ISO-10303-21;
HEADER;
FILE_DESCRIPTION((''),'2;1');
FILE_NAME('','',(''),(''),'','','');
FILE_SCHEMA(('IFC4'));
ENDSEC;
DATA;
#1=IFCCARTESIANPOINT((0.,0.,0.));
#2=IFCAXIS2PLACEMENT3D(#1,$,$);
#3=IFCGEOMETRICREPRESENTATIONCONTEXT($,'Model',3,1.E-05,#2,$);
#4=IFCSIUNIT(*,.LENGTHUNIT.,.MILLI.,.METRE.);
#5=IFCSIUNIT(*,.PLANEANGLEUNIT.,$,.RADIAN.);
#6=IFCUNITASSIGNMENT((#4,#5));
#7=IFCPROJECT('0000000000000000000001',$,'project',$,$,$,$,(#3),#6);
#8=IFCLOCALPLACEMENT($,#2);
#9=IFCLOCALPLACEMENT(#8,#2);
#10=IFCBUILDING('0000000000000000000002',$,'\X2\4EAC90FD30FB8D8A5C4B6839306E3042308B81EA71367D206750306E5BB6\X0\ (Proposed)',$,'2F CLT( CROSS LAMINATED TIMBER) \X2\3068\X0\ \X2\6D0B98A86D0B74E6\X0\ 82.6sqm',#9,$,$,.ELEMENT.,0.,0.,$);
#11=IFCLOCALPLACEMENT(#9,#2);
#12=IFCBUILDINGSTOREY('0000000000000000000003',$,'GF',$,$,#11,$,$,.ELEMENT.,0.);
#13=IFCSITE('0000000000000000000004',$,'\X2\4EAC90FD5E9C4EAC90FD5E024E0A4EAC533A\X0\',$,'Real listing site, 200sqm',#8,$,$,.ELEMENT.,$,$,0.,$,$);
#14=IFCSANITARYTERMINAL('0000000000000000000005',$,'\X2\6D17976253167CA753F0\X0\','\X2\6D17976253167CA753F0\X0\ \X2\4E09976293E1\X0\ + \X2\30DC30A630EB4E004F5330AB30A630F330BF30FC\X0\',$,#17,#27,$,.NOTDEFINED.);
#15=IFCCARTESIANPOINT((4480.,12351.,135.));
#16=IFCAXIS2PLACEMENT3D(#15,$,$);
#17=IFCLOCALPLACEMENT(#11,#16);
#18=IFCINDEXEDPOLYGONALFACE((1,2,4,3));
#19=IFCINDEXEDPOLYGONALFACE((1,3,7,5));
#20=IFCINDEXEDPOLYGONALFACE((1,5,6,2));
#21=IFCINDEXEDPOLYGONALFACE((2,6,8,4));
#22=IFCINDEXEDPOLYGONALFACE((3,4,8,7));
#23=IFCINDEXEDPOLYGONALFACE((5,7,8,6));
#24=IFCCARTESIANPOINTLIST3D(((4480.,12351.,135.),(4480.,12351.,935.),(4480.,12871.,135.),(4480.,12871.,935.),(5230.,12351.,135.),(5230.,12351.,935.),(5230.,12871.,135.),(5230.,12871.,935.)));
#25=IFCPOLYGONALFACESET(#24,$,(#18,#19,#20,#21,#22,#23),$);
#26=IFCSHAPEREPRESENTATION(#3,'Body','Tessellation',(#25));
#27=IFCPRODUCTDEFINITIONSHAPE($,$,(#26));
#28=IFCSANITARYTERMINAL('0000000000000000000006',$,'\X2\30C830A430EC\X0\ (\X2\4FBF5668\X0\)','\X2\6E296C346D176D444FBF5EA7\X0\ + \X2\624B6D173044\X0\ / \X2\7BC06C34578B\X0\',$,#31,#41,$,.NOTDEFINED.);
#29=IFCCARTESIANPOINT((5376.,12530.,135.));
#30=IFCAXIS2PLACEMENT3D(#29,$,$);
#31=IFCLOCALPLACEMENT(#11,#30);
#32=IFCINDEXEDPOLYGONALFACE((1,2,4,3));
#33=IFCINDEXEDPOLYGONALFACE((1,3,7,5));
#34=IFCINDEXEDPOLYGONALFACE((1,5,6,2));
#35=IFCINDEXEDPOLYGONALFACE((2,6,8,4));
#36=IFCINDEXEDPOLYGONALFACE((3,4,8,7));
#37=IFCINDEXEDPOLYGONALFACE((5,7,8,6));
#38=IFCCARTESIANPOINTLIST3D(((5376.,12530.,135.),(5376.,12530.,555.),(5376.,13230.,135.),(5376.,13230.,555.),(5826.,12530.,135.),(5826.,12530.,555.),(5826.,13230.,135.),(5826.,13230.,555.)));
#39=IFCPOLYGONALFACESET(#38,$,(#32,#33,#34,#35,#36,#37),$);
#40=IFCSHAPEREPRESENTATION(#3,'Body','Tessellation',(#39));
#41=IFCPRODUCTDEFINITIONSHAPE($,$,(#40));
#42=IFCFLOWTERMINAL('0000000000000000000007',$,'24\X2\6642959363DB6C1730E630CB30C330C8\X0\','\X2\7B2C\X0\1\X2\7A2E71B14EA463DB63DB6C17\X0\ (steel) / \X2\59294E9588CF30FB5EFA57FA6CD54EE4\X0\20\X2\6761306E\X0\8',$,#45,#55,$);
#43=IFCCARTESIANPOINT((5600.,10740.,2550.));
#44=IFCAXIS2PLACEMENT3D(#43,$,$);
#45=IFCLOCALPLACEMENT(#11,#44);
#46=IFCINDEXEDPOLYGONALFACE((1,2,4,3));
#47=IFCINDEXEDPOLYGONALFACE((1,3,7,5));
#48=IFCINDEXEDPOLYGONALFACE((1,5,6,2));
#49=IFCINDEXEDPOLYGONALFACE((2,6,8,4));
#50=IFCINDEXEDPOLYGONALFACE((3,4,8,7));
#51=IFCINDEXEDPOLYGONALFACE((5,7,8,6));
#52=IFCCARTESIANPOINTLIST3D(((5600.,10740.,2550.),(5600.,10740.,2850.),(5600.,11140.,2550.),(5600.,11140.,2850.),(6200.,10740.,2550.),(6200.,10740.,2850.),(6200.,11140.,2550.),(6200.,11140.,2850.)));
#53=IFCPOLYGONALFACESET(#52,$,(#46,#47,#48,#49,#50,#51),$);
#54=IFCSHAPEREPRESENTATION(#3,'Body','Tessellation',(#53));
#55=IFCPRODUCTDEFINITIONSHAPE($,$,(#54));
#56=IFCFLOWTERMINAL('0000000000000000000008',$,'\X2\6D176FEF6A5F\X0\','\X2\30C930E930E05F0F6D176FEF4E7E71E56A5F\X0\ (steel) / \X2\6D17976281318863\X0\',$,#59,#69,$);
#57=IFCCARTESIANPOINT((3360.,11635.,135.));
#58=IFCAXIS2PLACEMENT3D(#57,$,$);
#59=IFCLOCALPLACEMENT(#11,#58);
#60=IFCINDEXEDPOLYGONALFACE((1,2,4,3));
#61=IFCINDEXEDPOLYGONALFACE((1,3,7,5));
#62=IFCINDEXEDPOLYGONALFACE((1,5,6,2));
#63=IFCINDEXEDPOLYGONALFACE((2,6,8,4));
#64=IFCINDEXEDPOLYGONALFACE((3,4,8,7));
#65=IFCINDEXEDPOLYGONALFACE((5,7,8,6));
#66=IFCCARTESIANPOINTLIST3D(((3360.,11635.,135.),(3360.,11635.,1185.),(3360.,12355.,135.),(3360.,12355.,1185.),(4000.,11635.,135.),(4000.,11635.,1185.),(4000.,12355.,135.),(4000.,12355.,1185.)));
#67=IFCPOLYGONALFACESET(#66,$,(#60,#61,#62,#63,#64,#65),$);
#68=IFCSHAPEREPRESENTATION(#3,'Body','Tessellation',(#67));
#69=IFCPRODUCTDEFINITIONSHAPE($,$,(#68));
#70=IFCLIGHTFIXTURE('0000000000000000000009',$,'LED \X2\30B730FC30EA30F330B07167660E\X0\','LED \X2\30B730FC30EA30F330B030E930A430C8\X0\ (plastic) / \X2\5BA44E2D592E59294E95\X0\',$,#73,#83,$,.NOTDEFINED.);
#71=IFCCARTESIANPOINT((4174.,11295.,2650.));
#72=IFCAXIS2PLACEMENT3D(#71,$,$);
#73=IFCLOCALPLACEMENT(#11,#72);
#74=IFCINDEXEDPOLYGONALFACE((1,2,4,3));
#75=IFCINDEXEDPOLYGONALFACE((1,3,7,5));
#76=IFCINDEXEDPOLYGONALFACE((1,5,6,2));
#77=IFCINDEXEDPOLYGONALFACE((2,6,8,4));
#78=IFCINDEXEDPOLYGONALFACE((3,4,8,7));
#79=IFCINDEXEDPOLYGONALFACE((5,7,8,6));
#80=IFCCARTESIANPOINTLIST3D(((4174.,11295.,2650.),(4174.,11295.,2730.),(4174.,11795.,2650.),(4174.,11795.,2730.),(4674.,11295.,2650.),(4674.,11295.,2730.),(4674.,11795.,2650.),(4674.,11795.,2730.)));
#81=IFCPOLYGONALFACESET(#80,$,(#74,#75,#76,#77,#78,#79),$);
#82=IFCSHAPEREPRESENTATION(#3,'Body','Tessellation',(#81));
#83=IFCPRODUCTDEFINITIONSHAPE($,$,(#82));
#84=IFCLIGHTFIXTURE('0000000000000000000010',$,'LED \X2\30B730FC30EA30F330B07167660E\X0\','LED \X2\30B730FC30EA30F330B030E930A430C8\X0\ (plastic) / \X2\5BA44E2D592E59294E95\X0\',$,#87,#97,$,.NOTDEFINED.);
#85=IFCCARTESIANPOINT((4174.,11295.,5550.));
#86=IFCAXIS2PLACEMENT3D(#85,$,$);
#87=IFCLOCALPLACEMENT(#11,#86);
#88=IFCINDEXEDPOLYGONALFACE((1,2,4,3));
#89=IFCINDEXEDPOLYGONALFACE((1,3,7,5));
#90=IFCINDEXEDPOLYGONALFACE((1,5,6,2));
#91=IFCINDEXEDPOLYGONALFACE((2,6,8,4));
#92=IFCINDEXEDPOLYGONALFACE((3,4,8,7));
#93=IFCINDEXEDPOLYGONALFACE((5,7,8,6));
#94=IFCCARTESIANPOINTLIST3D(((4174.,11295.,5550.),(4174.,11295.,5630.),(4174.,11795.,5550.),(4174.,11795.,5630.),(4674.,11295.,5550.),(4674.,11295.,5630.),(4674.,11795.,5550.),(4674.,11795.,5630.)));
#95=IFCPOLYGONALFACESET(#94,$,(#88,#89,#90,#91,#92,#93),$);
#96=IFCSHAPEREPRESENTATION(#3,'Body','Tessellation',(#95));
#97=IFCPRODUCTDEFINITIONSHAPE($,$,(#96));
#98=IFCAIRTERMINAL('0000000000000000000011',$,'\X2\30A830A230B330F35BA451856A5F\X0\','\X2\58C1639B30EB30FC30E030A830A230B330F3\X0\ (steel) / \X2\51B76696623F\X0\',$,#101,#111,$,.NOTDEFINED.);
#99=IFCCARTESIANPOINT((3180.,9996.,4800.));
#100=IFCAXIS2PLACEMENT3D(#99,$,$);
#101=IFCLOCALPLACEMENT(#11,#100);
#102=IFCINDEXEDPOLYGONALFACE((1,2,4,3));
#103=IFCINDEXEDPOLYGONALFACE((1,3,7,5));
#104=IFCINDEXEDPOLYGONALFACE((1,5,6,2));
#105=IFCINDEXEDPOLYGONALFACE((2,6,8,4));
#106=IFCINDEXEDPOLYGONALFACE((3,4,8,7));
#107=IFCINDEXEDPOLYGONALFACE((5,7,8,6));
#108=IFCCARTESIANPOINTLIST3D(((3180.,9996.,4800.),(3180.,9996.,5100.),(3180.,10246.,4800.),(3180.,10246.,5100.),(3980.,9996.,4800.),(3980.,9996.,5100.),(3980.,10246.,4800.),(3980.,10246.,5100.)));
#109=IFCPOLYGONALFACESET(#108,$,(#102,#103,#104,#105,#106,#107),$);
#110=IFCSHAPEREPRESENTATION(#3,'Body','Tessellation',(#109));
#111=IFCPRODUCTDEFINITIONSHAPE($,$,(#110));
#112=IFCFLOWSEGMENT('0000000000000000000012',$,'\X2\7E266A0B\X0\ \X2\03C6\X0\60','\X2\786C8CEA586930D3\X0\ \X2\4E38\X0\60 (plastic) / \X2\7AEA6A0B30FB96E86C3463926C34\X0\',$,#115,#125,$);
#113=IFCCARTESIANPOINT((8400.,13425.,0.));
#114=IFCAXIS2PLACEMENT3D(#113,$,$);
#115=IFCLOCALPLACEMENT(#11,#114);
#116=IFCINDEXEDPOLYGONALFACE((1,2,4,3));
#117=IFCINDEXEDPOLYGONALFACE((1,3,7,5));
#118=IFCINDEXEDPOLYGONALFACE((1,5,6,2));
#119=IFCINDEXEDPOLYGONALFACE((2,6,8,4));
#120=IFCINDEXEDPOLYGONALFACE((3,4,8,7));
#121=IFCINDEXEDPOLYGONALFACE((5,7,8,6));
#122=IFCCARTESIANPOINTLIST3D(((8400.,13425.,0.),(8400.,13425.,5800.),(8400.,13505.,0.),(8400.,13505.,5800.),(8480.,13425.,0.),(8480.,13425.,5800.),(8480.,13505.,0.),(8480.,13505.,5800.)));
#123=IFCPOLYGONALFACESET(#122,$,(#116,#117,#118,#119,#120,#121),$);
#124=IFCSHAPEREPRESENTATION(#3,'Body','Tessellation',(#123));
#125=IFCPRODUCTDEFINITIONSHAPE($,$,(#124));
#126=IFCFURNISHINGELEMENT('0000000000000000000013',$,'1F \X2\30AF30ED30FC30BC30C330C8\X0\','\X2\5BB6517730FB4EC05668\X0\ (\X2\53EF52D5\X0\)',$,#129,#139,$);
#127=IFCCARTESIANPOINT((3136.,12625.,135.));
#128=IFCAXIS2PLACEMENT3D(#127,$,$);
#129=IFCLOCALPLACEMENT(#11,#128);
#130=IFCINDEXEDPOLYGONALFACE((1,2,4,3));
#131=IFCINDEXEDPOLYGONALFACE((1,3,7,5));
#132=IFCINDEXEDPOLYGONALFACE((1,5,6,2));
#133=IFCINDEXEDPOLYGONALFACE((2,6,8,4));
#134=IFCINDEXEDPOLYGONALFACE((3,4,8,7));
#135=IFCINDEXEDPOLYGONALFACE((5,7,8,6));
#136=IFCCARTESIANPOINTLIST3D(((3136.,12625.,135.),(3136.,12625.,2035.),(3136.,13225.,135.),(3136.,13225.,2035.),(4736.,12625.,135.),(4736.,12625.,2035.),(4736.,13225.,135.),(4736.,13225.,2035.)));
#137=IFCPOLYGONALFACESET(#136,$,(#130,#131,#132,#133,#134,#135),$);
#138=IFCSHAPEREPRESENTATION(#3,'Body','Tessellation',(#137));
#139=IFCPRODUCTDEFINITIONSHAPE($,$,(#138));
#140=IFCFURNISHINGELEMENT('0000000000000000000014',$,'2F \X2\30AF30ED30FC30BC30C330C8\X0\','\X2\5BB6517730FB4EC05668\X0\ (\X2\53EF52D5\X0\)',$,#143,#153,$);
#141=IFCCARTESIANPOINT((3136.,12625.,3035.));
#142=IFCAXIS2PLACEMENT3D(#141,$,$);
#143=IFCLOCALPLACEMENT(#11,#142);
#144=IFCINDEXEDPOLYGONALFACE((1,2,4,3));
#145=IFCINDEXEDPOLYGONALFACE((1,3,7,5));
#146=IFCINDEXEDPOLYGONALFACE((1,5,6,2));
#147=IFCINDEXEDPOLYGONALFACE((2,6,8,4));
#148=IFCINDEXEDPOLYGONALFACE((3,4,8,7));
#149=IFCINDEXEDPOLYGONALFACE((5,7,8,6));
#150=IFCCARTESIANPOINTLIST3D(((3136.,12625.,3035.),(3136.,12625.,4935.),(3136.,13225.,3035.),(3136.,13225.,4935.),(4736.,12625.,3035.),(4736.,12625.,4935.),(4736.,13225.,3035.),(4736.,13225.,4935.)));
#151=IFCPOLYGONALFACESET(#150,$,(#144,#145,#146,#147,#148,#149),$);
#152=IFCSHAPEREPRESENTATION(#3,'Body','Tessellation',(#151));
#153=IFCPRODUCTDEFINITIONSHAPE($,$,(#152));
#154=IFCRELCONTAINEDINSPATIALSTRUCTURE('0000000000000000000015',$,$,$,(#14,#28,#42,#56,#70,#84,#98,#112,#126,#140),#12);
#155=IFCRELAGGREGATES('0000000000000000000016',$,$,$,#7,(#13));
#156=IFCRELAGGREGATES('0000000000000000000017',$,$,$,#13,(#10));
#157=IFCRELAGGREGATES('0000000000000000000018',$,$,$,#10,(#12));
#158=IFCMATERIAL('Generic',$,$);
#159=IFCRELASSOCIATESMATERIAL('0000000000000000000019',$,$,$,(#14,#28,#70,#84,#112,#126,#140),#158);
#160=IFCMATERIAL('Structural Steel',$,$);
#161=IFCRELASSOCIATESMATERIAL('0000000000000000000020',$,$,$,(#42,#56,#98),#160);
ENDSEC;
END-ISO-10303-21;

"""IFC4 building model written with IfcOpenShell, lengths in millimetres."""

from ifc_helpers import new_model, si_unit, frame, frame_2d, origin, place, context, project, spatial, rectangle, extrude, material, element, save


model = new_model("IFC4")

# Units and contexts
model_context = context("Model", 3, precision=1e-05, world=origin())
ifc_project = project(units=[si_unit("LENGTHUNIT", "METRE", prefix="MILLI"), si_unit("PLANEANGLEUNIT", "RADIAN")], contexts=[model_context])

# Site, building, storey
site_placement = place(None, origin())
site = spatial("IfcSite", under=ifc_project, at=site_placement, Name="京都府京都市上京区", ObjectType="Real listing site, 200sqm", CompositionType="ELEMENT", RefElevation=0.0)
building_placement = place(site_placement, origin())
building = spatial("IfcBuilding", under=site, at=building_placement, Name="京都・越屋根のある自然素材の家 (Proposed)", ObjectType="2F CLT( CROSS LAMINATED TIMBER) と 洋風洋瓦 82.6sqm", CompositionType="ELEMENT", ElevationOfRefHeight=0.0, ElevationOfTerrain=0.0)
storey_placement = place(building_placement, origin())
storey = spatial("IfcBuildingStorey", under=building, at=storey_placement, Name="GF", CompositionType="ELEMENT", Elevation=0.0)

# Sanitary terminals
ifc_material_1 = material(Name="Generic")
sanitary_terminal_1_placement = place(storey_placement, frame((4480.0, 12351.0, 135.0)))
element("IfcSanitaryTerminal", 1, at=sanitary_terminal_1_placement, inside=storey, material=ifc_material_1, Name="洗面化粧台", Description="洗面化粧台 三面鏡 + ボウル一体カウンター", PredefinedType="NOTDEFINED", context=model_context, shape_type="SweptSolid", body=[
    extrude(rectangle(XDim=750.0, YDim=520.0, at=frame_2d((375.0, 260.0))), frame((4480.0, 12351.0, 135.0)), (0.0, 0.0, 1.0), 800.0),
])
sanitary_terminal_2_placement = place(storey_placement, frame((5376.0, 12530.0, 135.0)))
element("IfcSanitaryTerminal", 2, at=sanitary_terminal_2_placement, inside=storey, material=ifc_material_1, Name="トイレ (便器)", Description="温水洗浄便座 + 手洗い / 節水型", PredefinedType="NOTDEFINED", context=model_context, shape_type="SweptSolid", body=[
    extrude(rectangle(XDim=450.0, YDim=700.0, at=frame_2d((225.0, 350.0))), frame((5376.0, 12530.0, 135.0)), (0.0, 0.0, 1.0), 420.0),
])

# Flow terminals
ifc_material_2 = material(Name="Structural Steel")
flow_terminal_1_placement = place(storey_placement, frame((5600.0, 10740.0, 2550.0)))
element("IfcFlowTerminal", 3, at=flow_terminal_1_placement, inside=storey, material=ifc_material_2, Name="24時間換気ユニット", Description="第1種熱交換換気 (steel) / 天井裏・建基法令20条の8", context=model_context, shape_type="SweptSolid", body=[
    extrude(rectangle(XDim=600.0, YDim=400.0, at=frame_2d((300.0, 200.0))), frame((5600.0, 10740.0, 2550.0)), (0.0, 0.0, 1.0), 300.0),
])
flow_terminal_2_placement = place(storey_placement, frame((3360.0, 11635.0, 135.0)))
element("IfcFlowTerminal", 4, at=flow_terminal_2_placement, inside=storey, material=ifc_material_2, Name="洗濯機", Description="ドラム式洗濯乾燥機 (steel) / 洗面脱衣", context=model_context, shape_type="SweptSolid", body=[
    extrude(rectangle(XDim=640.0, YDim=720.0, at=frame_2d((320.0, 360.0))), frame((3360.0, 11635.0, 135.0)), (0.0, 0.0, 1.0), 1050.0),
])

# Light fixtures
light_fixture_1_placement = place(storey_placement, frame((4174.0, 11295.0, 2650.0)))
element("IfcLightFixture", 5, at=light_fixture_1_placement, inside=storey, material=ifc_material_1, Name="LED シーリング照明", Description="LED シーリングライト (plastic) / 室中央天井", PredefinedType="NOTDEFINED", context=model_context, shape_type="SweptSolid", body=[
    extrude(rectangle(XDim=500.0, YDim=500.0, at=frame_2d((250.0, 250.0))), frame((4174.0, 11295.0, 2650.0)), (0.0, 0.0, 1.0), 80.0),
])
light_fixture_2_placement = place(storey_placement, frame((4174.0, 11295.0, 5550.0)))
element("IfcLightFixture", 6, at=light_fixture_2_placement, inside=storey, material=ifc_material_1, Name="LED シーリング照明", Description="LED シーリングライト (plastic) / 室中央天井", PredefinedType="NOTDEFINED", context=model_context, shape_type="SweptSolid", body=[
    extrude(rectangle(XDim=500.0, YDim=500.0, at=frame_2d((250.0, 250.0))), frame((4174.0, 11295.0, 5550.0)), (0.0, 0.0, 1.0), 80.0),
])

# Air terminal
air_terminal_placement = place(storey_placement, frame((3180.0, 9996.0, 4800.0)))
element("IfcAirTerminal", 7, at=air_terminal_placement, inside=storey, material=ifc_material_2, Name="エアコン室内機", Description="壁掛ルームエアコン (steel) / 冷暖房", PredefinedType="NOTDEFINED", context=model_context, shape_type="SweptSolid", body=[
    extrude(rectangle(XDim=800.0, YDim=250.0, at=frame_2d((400.0, 125.0))), frame((3180.0, 9996.0, 4800.0)), (0.0, 0.0, 1.0), 300.0),
])

# Flow segment
flow_segment_placement = place(storey_placement, frame((8400.0, 13425.0, 0.0)))
element("IfcFlowSegment", 8, at=flow_segment_placement, inside=storey, material=ifc_material_1, Name="縦樋 φ60", Description="硬質塩ビ 丸60 (plastic) / 竪樋・雨水排水", context=model_context, shape_type="SweptSolid", body=[
    extrude(rectangle(XDim=80.0, YDim=80.0, at=frame_2d((40.0, 40.0))), frame((8400.0, 13425.0, 0.0)), (0.0, 0.0, 1.0), 5800.0),
])

# Furnishing elements
furnishing_1_placement = place(storey_placement, frame((3136.0, 12625.0, 135.0)))
element("IfcFurnishingElement", 9, at=furnishing_1_placement, inside=storey, material=ifc_material_1, Name="1F クローゼット", Description="家具・什器 (可動)", context=model_context, shape_type="SweptSolid", body=[
    extrude(rectangle(XDim=1600.0, YDim=600.0, at=frame_2d((800.0, 300.0))), frame((3136.0, 12625.0, 135.0)), (0.0, 0.0, 1.0), 1900.0),
])
furnishing_2_placement = place(storey_placement, frame((3136.0, 12625.0, 3035.0)))
element("IfcFurnishingElement", 10, at=furnishing_2_placement, inside=storey, material=ifc_material_1, Name="2F クローゼット", Description="家具・什器 (可動)", context=model_context, shape_type="SweptSolid", body=[
    extrude(rectangle(XDim=1600.0, YDim=600.0, at=frame_2d((800.0, 300.0))), frame((3136.0, 12625.0, 3035.0)), (0.0, 0.0, 1.0), 1900.0),
])

save(model, "model.ifc")
